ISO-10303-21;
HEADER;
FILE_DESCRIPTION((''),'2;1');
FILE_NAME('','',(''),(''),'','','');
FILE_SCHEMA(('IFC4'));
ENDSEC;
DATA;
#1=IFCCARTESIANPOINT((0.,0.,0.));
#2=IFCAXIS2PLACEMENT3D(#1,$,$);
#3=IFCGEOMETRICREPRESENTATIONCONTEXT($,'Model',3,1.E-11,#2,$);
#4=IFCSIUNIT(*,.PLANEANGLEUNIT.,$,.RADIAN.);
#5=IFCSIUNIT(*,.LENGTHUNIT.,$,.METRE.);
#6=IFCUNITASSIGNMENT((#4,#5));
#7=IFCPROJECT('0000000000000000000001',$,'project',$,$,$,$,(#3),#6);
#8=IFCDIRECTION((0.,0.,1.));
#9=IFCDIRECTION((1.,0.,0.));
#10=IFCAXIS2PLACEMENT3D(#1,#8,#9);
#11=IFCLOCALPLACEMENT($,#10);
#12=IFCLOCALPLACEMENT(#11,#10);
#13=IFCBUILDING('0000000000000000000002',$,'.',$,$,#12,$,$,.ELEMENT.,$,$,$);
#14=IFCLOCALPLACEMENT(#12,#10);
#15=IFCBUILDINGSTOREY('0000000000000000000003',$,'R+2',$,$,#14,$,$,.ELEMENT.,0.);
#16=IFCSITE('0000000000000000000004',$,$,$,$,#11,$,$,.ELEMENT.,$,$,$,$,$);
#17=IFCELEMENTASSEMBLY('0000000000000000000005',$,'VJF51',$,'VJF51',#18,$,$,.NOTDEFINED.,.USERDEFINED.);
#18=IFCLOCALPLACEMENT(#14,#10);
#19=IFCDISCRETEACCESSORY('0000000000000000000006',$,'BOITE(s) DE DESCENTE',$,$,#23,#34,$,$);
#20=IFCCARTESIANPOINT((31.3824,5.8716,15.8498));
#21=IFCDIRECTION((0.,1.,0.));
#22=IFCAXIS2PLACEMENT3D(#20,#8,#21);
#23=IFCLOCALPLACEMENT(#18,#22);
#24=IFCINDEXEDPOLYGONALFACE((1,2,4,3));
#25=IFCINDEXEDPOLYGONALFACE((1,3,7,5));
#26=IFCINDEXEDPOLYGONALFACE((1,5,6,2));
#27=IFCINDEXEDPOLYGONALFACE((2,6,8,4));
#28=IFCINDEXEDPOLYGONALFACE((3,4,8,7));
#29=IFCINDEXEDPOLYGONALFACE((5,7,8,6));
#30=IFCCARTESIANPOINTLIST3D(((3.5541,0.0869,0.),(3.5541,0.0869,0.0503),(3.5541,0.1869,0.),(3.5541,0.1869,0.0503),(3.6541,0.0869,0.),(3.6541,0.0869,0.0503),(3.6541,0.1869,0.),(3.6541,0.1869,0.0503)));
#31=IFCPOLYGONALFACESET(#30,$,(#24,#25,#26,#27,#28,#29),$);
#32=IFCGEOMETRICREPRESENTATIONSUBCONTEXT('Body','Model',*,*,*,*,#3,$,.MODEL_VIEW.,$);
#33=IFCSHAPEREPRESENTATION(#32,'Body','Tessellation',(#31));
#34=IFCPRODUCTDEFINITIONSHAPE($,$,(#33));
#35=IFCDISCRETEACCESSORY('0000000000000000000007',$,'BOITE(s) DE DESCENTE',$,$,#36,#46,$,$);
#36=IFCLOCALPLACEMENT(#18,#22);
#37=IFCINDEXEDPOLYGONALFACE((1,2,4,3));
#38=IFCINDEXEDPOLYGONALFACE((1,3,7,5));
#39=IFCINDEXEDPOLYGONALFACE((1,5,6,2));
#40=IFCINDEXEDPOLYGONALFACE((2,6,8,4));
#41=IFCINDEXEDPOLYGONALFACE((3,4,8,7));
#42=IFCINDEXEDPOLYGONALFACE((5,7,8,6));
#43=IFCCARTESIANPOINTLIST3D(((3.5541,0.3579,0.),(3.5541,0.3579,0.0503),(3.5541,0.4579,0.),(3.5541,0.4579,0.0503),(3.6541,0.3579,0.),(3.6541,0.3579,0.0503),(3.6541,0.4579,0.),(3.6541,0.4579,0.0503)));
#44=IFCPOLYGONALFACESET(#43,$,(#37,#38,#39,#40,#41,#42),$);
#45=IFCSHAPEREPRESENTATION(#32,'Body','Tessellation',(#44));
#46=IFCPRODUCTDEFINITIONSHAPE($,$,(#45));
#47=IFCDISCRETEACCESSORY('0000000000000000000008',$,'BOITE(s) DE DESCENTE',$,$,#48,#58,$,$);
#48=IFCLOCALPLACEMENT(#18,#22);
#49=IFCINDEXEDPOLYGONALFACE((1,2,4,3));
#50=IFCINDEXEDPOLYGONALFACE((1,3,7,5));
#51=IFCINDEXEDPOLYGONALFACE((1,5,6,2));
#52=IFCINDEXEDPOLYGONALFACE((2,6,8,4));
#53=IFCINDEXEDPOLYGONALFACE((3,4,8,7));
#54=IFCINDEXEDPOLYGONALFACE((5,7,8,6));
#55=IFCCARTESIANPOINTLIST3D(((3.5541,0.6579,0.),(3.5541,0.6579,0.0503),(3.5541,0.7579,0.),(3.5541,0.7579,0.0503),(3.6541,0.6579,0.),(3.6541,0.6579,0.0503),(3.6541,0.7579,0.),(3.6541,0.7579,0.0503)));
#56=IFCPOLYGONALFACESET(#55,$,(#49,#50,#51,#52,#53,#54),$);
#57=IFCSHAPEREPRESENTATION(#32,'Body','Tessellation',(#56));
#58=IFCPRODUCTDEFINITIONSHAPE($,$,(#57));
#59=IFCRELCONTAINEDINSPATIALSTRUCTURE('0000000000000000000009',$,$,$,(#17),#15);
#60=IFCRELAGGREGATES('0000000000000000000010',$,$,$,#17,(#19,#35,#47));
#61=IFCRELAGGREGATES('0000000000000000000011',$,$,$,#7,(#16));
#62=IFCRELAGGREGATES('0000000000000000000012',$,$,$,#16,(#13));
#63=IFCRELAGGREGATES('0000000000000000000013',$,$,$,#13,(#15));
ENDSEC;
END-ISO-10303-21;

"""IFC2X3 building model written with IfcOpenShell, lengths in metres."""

from ifc_helpers import new_model, si_unit, frame, origin, origin_with_axes, place, context, subcontext, project, spatial, polyline, outline, extrude, element, aggregate, save


model = new_model("IFC2X3")

# Units and contexts
model_context = context("Model", 3, precision=1e-11, world=origin())
body_context = subcontext(model_context, "Body", "Model", "MODEL_VIEW")
ifc_project = project(units=[si_unit("PLANEANGLEUNIT", "RADIAN"), si_unit("LENGTHUNIT", "METRE")], contexts=[model_context])

# Site, building, storey
site_placement = place(None, origin_with_axes())
site = spatial("IfcSite", under=ifc_project, at=site_placement, CompositionType="ELEMENT")
building_placement = place(site_placement, origin_with_axes())
building = spatial("IfcBuilding", under=site, at=building_placement, Name=".", CompositionType="ELEMENT")
storey_placement = place(building_placement, origin_with_axes())
storey = spatial("IfcBuildingStorey", under=building, at=storey_placement, Name="R+2", CompositionType="ELEMENT", Elevation=0.0)

# Element assembly
assembly_1_placement = place(storey_placement, origin_with_axes())
assembly_1 = element("IfcElementAssembly", 1, at=assembly_1_placement, inside=storey, Name="VJF51", ObjectType="VJF51", AssemblyPlace="NOTDEFINED", PredefinedType="USERDEFINED")

# Discrete accessories
discrete_accessory_1_placement = place(assembly_1_placement, frame((31.3824, 5.8716, 15.8498), z_axis=(0.0, 0.0, 1.0), x_axis=(0.0, 1.0, 0.0)))
discrete_accessory_1 = element("IfcDiscreteAccessory", 2, at=discrete_accessory_1_placement, Name="BOITE(s) DE DESCENTE", context=body_context, shape_type="SweptSolid", body=[
    extrude(outline(polyline([(0.0869, -3.5541), (0.0869, -3.6541), (0.1869, -3.6541), (0.1869, -3.5541), (0.0869, -3.5541)])), frame((0.0, 0.0, 0.0), z_axis=(0.0, 0.0, 1.0), x_axis=(0.0, 1.0, 0.0)), (0.0, 0.0, 1.0), 0.0503),
])
discrete_accessory_2_placement = place(assembly_1_placement, frame((31.3824, 5.8716, 15.8498), z_axis=(0.0, 0.0, 1.0), x_axis=(0.0, 1.0, 0.0)))
discrete_accessory_2 = element("IfcDiscreteAccessory", 3, at=discrete_accessory_2_placement, Name="BOITE(s) DE DESCENTE", context=body_context, shape_type="SweptSolid", body=[
    extrude(outline(polyline([(0.3579, -3.5541), (0.3579, -3.6541), (0.4579, -3.6541), (0.4579, -3.5541), (0.3579, -3.5541)])), frame((0.0, 0.0, 0.0), z_axis=(0.0, 0.0, 1.0), x_axis=(0.0, 1.0, 0.0)), (0.0, 0.0, 1.0), 0.0503),
])
discrete_accessory_3_placement = place(assembly_1_placement, frame((31.3824, 5.8716, 15.8498), z_axis=(0.0, 0.0, 1.0), x_axis=(0.0, 1.0, 0.0)))
discrete_accessory_3 = element("IfcDiscreteAccessory", 4, at=discrete_accessory_3_placement, Name="BOITE(s) DE DESCENTE", context=body_context, shape_type="SweptSolid", body=[
    extrude(outline(polyline([(0.6579, -3.5541), (0.6579, -3.6541), (0.7579, -3.6541), (0.7579, -3.5541), (0.6579, -3.5541)])), frame((0.0, 0.0, 0.0), z_axis=(0.0, 0.0, 1.0), x_axis=(0.0, 1.0, 0.0)), (0.0, 0.0, 1.0), 0.0503),
])
aggregate(assembly_1, [discrete_accessory_1, discrete_accessory_2, discrete_accessory_3])

save(model, "model.ifc")
